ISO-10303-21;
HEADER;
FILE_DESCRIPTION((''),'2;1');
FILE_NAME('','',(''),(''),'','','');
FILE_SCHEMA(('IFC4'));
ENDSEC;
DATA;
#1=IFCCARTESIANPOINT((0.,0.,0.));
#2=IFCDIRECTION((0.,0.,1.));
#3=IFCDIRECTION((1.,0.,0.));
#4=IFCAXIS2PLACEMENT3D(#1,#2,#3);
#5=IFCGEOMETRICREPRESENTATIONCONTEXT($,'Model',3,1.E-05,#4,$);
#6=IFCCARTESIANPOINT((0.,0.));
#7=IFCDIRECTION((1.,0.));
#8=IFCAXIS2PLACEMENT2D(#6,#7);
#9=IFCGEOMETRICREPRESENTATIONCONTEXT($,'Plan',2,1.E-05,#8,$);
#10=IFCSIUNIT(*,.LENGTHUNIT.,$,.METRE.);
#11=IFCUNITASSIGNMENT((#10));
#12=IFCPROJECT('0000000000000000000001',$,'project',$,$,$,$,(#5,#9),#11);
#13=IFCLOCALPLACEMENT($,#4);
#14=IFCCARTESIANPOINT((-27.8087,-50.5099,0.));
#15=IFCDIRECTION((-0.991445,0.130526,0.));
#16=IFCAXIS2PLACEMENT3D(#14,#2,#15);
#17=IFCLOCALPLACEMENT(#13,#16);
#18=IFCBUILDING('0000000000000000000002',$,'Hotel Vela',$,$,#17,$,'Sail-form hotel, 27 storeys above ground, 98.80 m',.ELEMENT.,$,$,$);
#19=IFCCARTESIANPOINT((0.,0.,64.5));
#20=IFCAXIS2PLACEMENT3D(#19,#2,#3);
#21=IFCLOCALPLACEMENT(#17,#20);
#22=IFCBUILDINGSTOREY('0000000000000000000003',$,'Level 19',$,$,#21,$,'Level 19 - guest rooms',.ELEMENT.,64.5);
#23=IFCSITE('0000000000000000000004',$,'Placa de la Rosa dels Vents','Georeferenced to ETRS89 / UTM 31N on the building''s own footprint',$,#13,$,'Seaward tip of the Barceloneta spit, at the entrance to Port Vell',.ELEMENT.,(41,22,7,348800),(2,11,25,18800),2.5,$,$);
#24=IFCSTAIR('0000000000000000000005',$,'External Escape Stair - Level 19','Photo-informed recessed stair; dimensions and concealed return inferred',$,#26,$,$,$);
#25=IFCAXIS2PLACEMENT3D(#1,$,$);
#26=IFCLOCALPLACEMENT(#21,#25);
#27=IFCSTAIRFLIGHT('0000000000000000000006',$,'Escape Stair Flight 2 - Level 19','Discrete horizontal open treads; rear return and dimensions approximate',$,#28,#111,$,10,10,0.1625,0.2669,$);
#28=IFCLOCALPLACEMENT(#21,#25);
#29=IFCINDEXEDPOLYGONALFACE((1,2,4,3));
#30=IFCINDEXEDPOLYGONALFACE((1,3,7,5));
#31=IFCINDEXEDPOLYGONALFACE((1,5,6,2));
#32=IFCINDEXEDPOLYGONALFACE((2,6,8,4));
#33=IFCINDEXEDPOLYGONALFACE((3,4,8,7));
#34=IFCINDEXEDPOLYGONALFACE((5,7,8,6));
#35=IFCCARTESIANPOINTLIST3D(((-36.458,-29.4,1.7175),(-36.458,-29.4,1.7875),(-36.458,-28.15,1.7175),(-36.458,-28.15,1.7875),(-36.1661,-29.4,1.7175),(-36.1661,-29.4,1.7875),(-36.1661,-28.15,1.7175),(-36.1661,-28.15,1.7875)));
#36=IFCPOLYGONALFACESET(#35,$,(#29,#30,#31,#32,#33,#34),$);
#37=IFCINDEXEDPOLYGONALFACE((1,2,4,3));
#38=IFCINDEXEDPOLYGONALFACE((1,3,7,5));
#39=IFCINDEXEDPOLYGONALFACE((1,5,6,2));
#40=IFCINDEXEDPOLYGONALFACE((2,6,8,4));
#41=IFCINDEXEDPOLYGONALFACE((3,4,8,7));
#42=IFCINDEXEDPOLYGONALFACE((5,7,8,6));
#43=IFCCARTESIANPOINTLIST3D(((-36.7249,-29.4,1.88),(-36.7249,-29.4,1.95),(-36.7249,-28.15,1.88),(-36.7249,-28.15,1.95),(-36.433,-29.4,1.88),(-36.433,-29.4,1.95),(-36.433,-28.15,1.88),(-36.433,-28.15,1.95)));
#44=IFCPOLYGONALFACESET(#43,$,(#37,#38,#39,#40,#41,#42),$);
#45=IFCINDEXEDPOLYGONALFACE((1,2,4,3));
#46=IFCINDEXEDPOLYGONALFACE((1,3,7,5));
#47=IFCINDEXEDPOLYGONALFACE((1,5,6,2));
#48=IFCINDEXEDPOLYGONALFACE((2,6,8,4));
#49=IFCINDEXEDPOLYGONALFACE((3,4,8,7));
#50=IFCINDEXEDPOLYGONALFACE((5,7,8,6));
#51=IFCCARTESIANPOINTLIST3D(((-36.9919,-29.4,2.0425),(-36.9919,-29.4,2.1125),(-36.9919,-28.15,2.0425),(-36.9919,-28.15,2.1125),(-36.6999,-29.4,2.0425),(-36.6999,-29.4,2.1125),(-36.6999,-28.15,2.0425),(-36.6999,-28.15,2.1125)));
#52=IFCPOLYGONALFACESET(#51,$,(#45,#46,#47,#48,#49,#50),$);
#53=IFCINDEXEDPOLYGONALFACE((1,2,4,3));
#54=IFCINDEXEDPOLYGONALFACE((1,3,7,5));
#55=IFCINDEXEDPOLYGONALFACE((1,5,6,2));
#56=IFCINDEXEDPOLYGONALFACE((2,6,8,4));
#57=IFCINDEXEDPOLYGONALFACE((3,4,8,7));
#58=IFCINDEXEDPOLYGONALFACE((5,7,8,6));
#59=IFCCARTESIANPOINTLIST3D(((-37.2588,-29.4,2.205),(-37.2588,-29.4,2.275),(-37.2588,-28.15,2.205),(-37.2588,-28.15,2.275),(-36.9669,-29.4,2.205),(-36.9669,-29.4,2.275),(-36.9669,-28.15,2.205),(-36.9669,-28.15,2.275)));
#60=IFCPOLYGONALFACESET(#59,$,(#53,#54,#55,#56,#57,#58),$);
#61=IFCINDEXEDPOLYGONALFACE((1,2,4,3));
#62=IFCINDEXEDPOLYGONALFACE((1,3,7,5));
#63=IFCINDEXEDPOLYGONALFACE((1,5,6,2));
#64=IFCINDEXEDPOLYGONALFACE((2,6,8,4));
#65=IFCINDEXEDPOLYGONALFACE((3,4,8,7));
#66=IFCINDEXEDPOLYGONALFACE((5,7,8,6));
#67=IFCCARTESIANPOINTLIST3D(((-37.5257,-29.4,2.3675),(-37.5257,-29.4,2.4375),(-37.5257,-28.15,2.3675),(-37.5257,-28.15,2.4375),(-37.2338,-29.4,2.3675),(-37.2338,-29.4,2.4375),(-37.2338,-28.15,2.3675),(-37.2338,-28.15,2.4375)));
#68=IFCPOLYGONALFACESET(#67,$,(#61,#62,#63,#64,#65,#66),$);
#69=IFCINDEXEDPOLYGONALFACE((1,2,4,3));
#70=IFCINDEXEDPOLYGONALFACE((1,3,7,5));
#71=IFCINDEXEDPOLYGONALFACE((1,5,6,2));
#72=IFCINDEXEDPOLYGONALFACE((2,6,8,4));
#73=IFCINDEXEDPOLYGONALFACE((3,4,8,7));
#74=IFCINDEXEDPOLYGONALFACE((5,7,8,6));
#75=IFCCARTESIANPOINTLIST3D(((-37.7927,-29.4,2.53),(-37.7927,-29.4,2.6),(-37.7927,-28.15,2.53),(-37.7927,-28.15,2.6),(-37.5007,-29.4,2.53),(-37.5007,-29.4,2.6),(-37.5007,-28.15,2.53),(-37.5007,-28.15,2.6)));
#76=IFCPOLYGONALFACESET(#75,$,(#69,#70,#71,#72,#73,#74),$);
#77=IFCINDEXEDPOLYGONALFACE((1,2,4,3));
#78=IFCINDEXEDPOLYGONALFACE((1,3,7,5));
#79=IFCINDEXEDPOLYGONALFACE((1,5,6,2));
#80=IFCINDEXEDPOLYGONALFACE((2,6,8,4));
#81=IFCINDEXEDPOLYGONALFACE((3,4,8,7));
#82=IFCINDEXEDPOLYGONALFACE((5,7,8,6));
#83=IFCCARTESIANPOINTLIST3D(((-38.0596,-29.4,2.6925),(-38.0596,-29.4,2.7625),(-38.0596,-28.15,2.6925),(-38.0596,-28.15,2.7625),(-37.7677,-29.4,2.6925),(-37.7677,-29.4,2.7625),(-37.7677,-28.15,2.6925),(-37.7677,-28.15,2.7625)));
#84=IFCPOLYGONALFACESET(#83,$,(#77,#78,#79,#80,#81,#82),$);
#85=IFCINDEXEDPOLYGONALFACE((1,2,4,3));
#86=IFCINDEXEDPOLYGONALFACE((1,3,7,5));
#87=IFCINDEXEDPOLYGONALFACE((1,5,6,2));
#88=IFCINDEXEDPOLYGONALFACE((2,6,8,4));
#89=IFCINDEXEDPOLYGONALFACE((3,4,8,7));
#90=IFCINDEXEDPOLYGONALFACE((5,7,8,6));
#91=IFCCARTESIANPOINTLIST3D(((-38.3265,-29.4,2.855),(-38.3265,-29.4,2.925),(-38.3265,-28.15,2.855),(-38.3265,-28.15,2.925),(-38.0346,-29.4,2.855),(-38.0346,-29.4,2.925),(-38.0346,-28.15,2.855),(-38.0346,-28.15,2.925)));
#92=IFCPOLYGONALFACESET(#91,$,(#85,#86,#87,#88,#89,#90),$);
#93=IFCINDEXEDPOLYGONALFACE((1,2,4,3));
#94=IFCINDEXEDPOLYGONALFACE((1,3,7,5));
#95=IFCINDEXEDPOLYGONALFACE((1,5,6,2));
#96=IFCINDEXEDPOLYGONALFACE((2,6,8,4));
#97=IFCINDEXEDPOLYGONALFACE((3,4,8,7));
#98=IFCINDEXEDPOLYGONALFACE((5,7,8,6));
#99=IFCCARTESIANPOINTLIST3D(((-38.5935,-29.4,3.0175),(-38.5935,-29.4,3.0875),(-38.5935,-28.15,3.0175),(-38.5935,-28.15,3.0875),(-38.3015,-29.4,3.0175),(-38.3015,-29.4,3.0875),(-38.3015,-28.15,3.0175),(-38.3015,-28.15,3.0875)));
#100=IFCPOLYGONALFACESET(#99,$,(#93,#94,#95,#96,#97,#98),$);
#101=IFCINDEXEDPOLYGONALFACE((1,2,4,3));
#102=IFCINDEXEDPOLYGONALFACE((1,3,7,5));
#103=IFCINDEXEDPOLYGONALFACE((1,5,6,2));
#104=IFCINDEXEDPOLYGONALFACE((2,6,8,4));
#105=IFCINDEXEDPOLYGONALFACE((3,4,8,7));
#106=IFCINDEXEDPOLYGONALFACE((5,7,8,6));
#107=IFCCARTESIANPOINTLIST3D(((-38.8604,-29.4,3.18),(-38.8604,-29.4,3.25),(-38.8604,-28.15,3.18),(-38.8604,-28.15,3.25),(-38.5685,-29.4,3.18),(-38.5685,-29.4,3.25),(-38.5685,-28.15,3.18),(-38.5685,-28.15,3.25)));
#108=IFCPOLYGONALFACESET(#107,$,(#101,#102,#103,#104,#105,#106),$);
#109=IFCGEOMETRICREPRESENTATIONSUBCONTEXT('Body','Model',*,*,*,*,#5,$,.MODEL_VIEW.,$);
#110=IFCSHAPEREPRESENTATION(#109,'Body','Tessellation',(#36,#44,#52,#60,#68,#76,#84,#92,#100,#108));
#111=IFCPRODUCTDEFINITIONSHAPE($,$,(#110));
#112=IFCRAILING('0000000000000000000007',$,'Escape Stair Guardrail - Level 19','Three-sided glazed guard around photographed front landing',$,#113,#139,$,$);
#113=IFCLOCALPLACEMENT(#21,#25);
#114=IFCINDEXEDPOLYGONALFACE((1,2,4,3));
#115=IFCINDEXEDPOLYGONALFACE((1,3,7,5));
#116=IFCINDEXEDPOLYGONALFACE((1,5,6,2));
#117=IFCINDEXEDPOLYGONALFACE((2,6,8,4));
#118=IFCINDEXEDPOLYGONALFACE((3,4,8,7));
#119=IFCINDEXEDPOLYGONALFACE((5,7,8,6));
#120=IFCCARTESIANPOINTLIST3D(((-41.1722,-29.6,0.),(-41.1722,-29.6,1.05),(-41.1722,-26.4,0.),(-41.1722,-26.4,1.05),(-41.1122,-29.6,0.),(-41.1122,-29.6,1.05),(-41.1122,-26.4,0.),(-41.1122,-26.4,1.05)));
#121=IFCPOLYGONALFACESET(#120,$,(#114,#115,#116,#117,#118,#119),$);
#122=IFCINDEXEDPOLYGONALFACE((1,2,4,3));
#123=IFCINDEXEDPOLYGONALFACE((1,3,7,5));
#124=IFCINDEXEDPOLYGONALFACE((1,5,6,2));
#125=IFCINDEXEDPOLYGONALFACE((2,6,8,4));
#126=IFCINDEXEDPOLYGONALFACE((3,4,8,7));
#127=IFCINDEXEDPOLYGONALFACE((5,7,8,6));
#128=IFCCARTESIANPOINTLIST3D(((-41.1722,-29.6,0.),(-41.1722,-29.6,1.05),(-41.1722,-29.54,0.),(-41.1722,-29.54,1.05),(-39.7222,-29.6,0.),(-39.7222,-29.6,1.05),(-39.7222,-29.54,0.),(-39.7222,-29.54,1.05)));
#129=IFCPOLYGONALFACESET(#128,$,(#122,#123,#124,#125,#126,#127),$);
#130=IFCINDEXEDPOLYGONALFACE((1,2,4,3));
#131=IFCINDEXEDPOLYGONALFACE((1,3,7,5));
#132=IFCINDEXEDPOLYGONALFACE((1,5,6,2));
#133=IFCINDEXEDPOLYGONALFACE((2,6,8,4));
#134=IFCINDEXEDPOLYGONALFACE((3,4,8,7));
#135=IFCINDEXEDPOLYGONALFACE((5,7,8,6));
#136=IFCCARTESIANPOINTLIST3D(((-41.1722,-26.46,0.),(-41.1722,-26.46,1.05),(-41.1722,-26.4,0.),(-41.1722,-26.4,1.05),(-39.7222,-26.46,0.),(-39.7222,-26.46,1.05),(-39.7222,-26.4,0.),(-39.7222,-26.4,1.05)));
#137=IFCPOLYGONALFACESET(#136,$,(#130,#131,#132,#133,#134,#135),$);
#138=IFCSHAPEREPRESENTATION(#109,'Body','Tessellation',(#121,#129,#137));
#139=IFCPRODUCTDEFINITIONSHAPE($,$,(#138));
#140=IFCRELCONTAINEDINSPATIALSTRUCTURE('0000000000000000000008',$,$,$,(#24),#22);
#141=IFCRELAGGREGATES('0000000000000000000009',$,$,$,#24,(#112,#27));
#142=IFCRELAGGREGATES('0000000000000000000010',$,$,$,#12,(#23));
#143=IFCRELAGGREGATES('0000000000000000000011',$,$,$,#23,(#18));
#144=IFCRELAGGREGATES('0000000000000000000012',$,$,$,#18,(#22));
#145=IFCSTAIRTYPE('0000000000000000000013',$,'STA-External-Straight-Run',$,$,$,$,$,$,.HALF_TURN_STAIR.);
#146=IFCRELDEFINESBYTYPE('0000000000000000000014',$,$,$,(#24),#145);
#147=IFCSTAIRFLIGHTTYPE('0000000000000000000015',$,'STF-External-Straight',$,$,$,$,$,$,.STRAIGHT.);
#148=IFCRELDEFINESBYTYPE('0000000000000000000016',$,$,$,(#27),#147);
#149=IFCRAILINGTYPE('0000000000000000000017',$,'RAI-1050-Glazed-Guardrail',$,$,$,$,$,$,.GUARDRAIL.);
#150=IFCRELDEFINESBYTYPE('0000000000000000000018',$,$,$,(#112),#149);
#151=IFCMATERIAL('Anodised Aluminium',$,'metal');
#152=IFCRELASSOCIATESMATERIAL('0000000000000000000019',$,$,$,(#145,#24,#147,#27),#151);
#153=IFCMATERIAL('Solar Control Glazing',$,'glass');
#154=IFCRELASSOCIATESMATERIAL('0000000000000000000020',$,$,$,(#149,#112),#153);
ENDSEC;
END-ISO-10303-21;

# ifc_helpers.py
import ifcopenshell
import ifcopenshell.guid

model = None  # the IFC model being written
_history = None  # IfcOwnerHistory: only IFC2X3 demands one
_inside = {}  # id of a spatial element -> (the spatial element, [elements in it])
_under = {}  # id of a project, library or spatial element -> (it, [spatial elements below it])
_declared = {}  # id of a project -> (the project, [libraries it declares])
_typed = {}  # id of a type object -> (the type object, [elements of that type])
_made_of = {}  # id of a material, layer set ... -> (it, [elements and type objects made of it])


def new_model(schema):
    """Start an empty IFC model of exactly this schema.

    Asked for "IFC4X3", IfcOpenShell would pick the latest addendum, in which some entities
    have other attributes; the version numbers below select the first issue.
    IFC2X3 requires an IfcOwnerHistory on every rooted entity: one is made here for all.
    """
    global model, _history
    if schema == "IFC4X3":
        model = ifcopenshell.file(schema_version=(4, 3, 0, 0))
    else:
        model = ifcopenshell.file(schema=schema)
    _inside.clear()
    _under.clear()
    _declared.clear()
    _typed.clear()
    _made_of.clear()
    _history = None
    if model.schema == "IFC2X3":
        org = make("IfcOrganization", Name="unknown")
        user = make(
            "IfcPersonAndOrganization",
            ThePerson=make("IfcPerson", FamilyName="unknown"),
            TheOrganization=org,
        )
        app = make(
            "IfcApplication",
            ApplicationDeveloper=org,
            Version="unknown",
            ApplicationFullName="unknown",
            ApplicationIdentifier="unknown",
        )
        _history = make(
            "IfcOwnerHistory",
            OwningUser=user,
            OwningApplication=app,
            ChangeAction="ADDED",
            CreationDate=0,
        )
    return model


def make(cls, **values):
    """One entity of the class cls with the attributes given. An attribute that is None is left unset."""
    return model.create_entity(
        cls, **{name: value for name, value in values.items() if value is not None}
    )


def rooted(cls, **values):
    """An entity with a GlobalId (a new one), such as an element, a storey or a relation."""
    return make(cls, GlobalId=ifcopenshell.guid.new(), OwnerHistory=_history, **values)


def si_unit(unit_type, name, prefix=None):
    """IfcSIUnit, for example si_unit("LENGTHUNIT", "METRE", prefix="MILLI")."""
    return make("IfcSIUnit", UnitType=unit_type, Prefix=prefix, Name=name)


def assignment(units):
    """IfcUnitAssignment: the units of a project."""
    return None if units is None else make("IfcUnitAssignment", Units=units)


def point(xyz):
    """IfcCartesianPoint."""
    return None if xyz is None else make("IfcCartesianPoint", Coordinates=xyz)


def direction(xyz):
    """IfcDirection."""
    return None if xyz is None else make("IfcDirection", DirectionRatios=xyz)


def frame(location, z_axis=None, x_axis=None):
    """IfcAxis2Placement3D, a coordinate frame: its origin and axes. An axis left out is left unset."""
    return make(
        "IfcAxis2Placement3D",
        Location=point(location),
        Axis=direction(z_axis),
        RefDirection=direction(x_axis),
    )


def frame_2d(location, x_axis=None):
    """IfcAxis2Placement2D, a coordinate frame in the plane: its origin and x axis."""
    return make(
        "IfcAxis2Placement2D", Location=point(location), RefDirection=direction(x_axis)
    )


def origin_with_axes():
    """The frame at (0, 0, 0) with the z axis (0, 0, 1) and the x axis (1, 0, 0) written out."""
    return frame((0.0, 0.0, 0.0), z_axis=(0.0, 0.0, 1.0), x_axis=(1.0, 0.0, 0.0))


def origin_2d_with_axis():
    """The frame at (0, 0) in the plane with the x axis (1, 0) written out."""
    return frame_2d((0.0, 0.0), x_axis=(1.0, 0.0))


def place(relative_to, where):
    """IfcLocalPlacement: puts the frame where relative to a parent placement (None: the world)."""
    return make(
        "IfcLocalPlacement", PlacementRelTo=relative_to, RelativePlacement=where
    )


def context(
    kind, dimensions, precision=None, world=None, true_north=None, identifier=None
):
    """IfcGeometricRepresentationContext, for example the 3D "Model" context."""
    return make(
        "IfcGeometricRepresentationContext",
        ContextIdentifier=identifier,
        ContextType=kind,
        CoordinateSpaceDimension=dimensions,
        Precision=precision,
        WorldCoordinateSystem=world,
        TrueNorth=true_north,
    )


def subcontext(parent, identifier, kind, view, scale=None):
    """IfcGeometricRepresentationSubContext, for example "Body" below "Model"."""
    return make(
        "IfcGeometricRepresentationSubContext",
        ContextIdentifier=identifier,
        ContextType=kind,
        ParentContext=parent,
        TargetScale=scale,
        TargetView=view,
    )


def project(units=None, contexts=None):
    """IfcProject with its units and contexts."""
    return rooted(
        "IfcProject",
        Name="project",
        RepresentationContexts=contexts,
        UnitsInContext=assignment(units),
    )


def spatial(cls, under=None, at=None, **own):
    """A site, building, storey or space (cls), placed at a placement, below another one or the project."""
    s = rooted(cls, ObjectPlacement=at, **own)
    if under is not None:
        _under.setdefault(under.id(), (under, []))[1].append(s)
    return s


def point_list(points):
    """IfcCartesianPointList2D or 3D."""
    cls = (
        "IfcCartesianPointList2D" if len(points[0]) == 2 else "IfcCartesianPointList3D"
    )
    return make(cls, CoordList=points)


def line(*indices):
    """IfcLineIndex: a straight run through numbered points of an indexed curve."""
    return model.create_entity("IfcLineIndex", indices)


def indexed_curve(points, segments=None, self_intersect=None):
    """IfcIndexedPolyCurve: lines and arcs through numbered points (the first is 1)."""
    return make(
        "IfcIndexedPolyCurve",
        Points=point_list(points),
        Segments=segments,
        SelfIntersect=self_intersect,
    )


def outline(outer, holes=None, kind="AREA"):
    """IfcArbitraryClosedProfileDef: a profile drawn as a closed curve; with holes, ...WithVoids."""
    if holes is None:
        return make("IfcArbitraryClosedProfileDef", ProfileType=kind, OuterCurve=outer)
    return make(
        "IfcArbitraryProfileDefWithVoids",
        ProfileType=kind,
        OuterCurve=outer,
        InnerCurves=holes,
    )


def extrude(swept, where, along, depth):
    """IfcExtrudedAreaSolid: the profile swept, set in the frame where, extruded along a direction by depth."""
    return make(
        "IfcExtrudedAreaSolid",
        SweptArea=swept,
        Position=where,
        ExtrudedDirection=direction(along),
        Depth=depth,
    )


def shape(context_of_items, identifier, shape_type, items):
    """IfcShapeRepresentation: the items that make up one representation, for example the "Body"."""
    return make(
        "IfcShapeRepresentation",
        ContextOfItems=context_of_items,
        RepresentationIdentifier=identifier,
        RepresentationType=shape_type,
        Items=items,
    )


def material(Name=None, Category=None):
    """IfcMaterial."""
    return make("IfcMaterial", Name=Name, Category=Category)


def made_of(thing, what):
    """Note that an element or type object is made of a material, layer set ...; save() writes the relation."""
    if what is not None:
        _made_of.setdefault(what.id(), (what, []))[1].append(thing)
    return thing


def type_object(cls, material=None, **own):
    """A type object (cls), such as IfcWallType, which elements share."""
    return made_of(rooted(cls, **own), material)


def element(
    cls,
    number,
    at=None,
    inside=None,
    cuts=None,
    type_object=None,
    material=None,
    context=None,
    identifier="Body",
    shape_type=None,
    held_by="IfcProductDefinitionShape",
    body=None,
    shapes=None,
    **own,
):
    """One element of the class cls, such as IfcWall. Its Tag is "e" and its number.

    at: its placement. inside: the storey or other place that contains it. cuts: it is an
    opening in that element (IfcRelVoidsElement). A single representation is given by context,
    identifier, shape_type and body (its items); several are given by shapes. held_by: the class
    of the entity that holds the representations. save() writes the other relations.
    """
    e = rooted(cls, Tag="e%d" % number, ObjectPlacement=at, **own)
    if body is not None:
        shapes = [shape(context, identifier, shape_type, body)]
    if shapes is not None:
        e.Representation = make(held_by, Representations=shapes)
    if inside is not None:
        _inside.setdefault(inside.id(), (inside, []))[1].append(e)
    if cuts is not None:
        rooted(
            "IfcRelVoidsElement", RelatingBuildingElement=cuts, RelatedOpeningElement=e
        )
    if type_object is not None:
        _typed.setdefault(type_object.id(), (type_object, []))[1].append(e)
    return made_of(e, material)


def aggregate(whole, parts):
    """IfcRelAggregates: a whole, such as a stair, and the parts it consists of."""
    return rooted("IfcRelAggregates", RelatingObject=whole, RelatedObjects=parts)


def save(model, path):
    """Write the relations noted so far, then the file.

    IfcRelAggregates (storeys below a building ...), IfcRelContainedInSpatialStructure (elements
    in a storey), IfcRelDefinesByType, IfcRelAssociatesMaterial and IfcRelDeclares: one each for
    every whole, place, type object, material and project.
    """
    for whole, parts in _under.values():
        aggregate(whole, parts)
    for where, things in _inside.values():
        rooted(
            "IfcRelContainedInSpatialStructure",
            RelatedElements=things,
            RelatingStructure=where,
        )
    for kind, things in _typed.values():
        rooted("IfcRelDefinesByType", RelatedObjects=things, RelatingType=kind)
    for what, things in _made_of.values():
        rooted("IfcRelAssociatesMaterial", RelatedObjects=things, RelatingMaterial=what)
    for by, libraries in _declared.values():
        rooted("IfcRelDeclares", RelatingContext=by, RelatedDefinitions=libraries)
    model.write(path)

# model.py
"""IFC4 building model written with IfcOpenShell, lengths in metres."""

from ifc_helpers import new_model, si_unit, frame, origin_with_axes, origin_2d_with_axis, place, context, subcontext, project, spatial, line, indexed_curve, outline, extrude, material, type_object, element, aggregate, save


model = new_model("IFC4")

# Units and contexts
model_context = context("Model", 3, precision=1e-05, world=origin_with_axes())
plan_context = context("Plan", 2, precision=1e-05, world=origin_2d_with_axis())
body_context = subcontext(model_context, "Body", "Model", "MODEL_VIEW")
ifc_project = project(units=[si_unit("LENGTHUNIT", "METRE")], contexts=[model_context, plan_context])

# Site, building, storey
site_placement = place(None, origin_with_axes())
site = spatial("IfcSite", under=ifc_project, at=site_placement, Name="Placa de la Rosa dels Vents", Description="Georeferenced to ETRS89 / UTM 31N on the building's own footprint", LongName="Seaward tip of the Barceloneta spit, at the entrance to Port Vell", CompositionType="ELEMENT", RefLatitude=(41, 22, 7, 348800), RefLongitude=(2, 11, 25, 18800), RefElevation=2.5)
building_placement = place(site_placement, frame((-27.8087, -50.5099, 0.0), z_axis=(0.0, 0.0, 1.0), x_axis=(-0.991445, 0.130526, 0.0)))
building = spatial("IfcBuilding", under=site, at=building_placement, Name="Hotel Vela", LongName="Sail-form hotel, 27 storeys above ground, 98.80 m", CompositionType="ELEMENT")
storey_placement = place(building_placement, frame((0.0, 0.0, 64.5), z_axis=(0.0, 0.0, 1.0), x_axis=(1.0, 0.0, 0.0)))
storey = spatial("IfcBuildingStorey", under=building, at=storey_placement, Name="Level 19", LongName="Level 19 - guest rooms", CompositionType="ELEMENT", Elevation=64.5)

# Stair
ifc_material_1 = material(Name="Anodised Aluminium", Category="metal")
stair_type = type_object("IfcStairType", Name="STA-External-Straight-Run", PredefinedType="HALF_TURN_STAIR", material=ifc_material_1)
stair_placement = place(storey_placement, frame((0.0, 0.0, -64.5), z_axis=(0.0, 0.0, 1.0), x_axis=(1.0, 0.0, 0.0)))
stair = element("IfcStair", 1, at=stair_placement, inside=storey, type_object=stair_type, material=ifc_material_1, Name="External Escape Stair - Level 19", Description="Photo-informed recessed stair; dimensions and concealed return inferred")

# Stair flight
stair_flight_type = type_object("IfcStairFlightType", Name="STF-External-Straight", PredefinedType="STRAIGHT", material=ifc_material_1)
stair_flight_1_placement = place(stair_placement, origin_with_axes())
stair_flight_1 = element("IfcStairFlight", 2, at=stair_flight_1_placement, type_object=stair_flight_type, material=ifc_material_1, Name="Escape Stair Flight 2 - Level 19", Description="Discrete horizontal open treads; rear return and dimensions approximate", NumberOfRisers=10, NumberOfTreads=10, RiserHeight=0.1625, TreadLength=0.2669, context=body_context, shape_type="SweptSolid", body=[
    extrude(outline(indexed_curve([(0.0, 0.0), (0.2919, 0.0), (0.2919, 1.25), (0.0, 1.25)], segments=[line(1, 2, 3, 4, 1)])), frame((-36.458, -29.4, 66.2175), z_axis=(0.0, 0.0, 1.0), x_axis=(1.0, 0.0, 0.0)), (0.0, 0.0, 1.0), 0.07),
    extrude(outline(indexed_curve([(0.0, 0.0), (0.2919, 0.0), (0.2919, 1.25), (0.0, 1.25)], segments=[line(1, 2, 3, 4, 1)])), frame((-36.7249, -29.4, 66.38), z_axis=(0.0, 0.0, 1.0), x_axis=(1.0, 0.0, 0.0)), (0.0, 0.0, 1.0), 0.07),
    extrude(outline(indexed_curve([(0.0, 0.0), (0.2919, 0.0), (0.2919, 1.25), (0.0, 1.25)], segments=[line(1, 2, 3, 4, 1)])), frame((-36.9919, -29.4, 66.5425), z_axis=(0.0, 0.0, 1.0), x_axis=(1.0, 0.0, 0.0)), (0.0, 0.0, 1.0), 0.07),
    extrude(outline(indexed_curve([(0.0, 0.0), (0.2919, 0.0), (0.2919, 1.25), (0.0, 1.25)], segments=[line(1, 2, 3, 4, 1)])), frame((-37.2588, -29.4, 66.705), z_axis=(0.0, 0.0, 1.0), x_axis=(1.0, 0.0, 0.0)), (0.0, 0.0, 1.0), 0.07),
    extrude(outline(indexed_curve([(0.0, 0.0), (0.2919, 0.0), (0.2919, 1.25), (0.0, 1.25)], segments=[line(1, 2, 3, 4, 1)])), frame((-37.5257, -29.4, 66.8675), z_axis=(0.0, 0.0, 1.0), x_axis=(1.0, 0.0, 0.0)), (0.0, 0.0, 1.0), 0.07),
    extrude(outline(indexed_curve([(0.0, 0.0), (0.2919, 0.0), (0.2919, 1.25), (0.0, 1.25)], segments=[line(1, 2, 3, 4, 1)])), frame((-37.7927, -29.4, 67.03), z_axis=(0.0, 0.0, 1.0), x_axis=(1.0, 0.0, 0.0)), (0.0, 0.0, 1.0), 0.07),
    extrude(outline(indexed_curve([(0.0, 0.0), (0.2919, 0.0), (0.2919, 1.25), (0.0, 1.25)], segments=[line(1, 2, 3, 4, 1)])), frame((-38.0596, -29.4, 67.1925), z_axis=(0.0, 0.0, 1.0), x_axis=(1.0, 0.0, 0.0)), (0.0, 0.0, 1.0), 0.07),
    extrude(outline(indexed_curve([(0.0, 0.0), (0.2919, 0.0), (0.2919, 1.25), (0.0, 1.25)], segments=[line(1, 2, 3, 4, 1)])), frame((-38.3265, -29.4, 67.355), z_axis=(0.0, 0.0, 1.0), x_axis=(1.0, 0.0, 0.0)), (0.0, 0.0, 1.0), 0.07),
    extrude(outline(indexed_curve([(0.0, 0.0), (0.2919, 0.0), (0.2919, 1.25), (0.0, 1.25)], segments=[line(1, 2, 3, 4, 1)])), frame((-38.5935, -29.4, 67.5175), z_axis=(0.0, 0.0, 1.0), x_axis=(1.0, 0.0, 0.0)), (0.0, 0.0, 1.0), 0.07),
    extrude(outline(indexed_curve([(0.0, 0.0), (0.2919, 0.0), (0.2919, 1.25), (0.0, 1.25)], segments=[line(1, 2, 3, 4, 1)])), frame((-38.8604, -29.4, 67.68), z_axis=(0.0, 0.0, 1.0), x_axis=(1.0, 0.0, 0.0)), (0.0, 0.0, 1.0), 0.07),
])

# Railing
ifc_material_2 = material(Name="Solar Control Glazing", Category="glass")
railing_type = type_object("IfcRailingType", Name="RAI-1050-Glazed-Guardrail", PredefinedType="GUARDRAIL", material=ifc_material_2)
railing_placement = place(stair_placement, origin_with_axes())
railing = element("IfcRailing", 3, at=railing_placement, type_object=railing_type, material=ifc_material_2, Name="Escape Stair Guardrail - Level 19", Description="Three-sided glazed guard around photographed front landing", context=body_context, shape_type="SweptSolid", body=[
    extrude(outline(indexed_curve([(0.0, 0.0), (0.06, 0.0), (0.06, 3.2), (0.0, 3.2)], segments=[line(1, 2, 3, 4, 1)])), frame((-41.1722, -29.6, 64.5), z_axis=(0.0, 0.0, 1.0), x_axis=(1.0, 0.0, 0.0)), (0.0, 0.0, 1.0), 1.05),
    extrude(outline(indexed_curve([(0.0, 0.0), (1.45, 0.0), (1.45, 0.06), (0.0, 0.06)], segments=[line(1, 2, 3, 4, 1)])), frame((-41.1722, -29.6, 64.5), z_axis=(0.0, 0.0, 1.0), x_axis=(1.0, 0.0, 0.0)), (0.0, 0.0, 1.0), 1.05),
    extrude(outline(indexed_curve([(0.0, 0.0), (1.45, 0.0), (1.45, 0.06), (0.0, 0.06)], segments=[line(1, 2, 3, 4, 1)])), frame((-41.1722, -26.46, 64.5), z_axis=(0.0, 0.0, 1.0), x_axis=(1.0, 0.0, 0.0)), (0.0, 0.0, 1.0), 1.05),
])
aggregate(stair, [railing, stair_flight_1])

save(model, "model.ifc")
